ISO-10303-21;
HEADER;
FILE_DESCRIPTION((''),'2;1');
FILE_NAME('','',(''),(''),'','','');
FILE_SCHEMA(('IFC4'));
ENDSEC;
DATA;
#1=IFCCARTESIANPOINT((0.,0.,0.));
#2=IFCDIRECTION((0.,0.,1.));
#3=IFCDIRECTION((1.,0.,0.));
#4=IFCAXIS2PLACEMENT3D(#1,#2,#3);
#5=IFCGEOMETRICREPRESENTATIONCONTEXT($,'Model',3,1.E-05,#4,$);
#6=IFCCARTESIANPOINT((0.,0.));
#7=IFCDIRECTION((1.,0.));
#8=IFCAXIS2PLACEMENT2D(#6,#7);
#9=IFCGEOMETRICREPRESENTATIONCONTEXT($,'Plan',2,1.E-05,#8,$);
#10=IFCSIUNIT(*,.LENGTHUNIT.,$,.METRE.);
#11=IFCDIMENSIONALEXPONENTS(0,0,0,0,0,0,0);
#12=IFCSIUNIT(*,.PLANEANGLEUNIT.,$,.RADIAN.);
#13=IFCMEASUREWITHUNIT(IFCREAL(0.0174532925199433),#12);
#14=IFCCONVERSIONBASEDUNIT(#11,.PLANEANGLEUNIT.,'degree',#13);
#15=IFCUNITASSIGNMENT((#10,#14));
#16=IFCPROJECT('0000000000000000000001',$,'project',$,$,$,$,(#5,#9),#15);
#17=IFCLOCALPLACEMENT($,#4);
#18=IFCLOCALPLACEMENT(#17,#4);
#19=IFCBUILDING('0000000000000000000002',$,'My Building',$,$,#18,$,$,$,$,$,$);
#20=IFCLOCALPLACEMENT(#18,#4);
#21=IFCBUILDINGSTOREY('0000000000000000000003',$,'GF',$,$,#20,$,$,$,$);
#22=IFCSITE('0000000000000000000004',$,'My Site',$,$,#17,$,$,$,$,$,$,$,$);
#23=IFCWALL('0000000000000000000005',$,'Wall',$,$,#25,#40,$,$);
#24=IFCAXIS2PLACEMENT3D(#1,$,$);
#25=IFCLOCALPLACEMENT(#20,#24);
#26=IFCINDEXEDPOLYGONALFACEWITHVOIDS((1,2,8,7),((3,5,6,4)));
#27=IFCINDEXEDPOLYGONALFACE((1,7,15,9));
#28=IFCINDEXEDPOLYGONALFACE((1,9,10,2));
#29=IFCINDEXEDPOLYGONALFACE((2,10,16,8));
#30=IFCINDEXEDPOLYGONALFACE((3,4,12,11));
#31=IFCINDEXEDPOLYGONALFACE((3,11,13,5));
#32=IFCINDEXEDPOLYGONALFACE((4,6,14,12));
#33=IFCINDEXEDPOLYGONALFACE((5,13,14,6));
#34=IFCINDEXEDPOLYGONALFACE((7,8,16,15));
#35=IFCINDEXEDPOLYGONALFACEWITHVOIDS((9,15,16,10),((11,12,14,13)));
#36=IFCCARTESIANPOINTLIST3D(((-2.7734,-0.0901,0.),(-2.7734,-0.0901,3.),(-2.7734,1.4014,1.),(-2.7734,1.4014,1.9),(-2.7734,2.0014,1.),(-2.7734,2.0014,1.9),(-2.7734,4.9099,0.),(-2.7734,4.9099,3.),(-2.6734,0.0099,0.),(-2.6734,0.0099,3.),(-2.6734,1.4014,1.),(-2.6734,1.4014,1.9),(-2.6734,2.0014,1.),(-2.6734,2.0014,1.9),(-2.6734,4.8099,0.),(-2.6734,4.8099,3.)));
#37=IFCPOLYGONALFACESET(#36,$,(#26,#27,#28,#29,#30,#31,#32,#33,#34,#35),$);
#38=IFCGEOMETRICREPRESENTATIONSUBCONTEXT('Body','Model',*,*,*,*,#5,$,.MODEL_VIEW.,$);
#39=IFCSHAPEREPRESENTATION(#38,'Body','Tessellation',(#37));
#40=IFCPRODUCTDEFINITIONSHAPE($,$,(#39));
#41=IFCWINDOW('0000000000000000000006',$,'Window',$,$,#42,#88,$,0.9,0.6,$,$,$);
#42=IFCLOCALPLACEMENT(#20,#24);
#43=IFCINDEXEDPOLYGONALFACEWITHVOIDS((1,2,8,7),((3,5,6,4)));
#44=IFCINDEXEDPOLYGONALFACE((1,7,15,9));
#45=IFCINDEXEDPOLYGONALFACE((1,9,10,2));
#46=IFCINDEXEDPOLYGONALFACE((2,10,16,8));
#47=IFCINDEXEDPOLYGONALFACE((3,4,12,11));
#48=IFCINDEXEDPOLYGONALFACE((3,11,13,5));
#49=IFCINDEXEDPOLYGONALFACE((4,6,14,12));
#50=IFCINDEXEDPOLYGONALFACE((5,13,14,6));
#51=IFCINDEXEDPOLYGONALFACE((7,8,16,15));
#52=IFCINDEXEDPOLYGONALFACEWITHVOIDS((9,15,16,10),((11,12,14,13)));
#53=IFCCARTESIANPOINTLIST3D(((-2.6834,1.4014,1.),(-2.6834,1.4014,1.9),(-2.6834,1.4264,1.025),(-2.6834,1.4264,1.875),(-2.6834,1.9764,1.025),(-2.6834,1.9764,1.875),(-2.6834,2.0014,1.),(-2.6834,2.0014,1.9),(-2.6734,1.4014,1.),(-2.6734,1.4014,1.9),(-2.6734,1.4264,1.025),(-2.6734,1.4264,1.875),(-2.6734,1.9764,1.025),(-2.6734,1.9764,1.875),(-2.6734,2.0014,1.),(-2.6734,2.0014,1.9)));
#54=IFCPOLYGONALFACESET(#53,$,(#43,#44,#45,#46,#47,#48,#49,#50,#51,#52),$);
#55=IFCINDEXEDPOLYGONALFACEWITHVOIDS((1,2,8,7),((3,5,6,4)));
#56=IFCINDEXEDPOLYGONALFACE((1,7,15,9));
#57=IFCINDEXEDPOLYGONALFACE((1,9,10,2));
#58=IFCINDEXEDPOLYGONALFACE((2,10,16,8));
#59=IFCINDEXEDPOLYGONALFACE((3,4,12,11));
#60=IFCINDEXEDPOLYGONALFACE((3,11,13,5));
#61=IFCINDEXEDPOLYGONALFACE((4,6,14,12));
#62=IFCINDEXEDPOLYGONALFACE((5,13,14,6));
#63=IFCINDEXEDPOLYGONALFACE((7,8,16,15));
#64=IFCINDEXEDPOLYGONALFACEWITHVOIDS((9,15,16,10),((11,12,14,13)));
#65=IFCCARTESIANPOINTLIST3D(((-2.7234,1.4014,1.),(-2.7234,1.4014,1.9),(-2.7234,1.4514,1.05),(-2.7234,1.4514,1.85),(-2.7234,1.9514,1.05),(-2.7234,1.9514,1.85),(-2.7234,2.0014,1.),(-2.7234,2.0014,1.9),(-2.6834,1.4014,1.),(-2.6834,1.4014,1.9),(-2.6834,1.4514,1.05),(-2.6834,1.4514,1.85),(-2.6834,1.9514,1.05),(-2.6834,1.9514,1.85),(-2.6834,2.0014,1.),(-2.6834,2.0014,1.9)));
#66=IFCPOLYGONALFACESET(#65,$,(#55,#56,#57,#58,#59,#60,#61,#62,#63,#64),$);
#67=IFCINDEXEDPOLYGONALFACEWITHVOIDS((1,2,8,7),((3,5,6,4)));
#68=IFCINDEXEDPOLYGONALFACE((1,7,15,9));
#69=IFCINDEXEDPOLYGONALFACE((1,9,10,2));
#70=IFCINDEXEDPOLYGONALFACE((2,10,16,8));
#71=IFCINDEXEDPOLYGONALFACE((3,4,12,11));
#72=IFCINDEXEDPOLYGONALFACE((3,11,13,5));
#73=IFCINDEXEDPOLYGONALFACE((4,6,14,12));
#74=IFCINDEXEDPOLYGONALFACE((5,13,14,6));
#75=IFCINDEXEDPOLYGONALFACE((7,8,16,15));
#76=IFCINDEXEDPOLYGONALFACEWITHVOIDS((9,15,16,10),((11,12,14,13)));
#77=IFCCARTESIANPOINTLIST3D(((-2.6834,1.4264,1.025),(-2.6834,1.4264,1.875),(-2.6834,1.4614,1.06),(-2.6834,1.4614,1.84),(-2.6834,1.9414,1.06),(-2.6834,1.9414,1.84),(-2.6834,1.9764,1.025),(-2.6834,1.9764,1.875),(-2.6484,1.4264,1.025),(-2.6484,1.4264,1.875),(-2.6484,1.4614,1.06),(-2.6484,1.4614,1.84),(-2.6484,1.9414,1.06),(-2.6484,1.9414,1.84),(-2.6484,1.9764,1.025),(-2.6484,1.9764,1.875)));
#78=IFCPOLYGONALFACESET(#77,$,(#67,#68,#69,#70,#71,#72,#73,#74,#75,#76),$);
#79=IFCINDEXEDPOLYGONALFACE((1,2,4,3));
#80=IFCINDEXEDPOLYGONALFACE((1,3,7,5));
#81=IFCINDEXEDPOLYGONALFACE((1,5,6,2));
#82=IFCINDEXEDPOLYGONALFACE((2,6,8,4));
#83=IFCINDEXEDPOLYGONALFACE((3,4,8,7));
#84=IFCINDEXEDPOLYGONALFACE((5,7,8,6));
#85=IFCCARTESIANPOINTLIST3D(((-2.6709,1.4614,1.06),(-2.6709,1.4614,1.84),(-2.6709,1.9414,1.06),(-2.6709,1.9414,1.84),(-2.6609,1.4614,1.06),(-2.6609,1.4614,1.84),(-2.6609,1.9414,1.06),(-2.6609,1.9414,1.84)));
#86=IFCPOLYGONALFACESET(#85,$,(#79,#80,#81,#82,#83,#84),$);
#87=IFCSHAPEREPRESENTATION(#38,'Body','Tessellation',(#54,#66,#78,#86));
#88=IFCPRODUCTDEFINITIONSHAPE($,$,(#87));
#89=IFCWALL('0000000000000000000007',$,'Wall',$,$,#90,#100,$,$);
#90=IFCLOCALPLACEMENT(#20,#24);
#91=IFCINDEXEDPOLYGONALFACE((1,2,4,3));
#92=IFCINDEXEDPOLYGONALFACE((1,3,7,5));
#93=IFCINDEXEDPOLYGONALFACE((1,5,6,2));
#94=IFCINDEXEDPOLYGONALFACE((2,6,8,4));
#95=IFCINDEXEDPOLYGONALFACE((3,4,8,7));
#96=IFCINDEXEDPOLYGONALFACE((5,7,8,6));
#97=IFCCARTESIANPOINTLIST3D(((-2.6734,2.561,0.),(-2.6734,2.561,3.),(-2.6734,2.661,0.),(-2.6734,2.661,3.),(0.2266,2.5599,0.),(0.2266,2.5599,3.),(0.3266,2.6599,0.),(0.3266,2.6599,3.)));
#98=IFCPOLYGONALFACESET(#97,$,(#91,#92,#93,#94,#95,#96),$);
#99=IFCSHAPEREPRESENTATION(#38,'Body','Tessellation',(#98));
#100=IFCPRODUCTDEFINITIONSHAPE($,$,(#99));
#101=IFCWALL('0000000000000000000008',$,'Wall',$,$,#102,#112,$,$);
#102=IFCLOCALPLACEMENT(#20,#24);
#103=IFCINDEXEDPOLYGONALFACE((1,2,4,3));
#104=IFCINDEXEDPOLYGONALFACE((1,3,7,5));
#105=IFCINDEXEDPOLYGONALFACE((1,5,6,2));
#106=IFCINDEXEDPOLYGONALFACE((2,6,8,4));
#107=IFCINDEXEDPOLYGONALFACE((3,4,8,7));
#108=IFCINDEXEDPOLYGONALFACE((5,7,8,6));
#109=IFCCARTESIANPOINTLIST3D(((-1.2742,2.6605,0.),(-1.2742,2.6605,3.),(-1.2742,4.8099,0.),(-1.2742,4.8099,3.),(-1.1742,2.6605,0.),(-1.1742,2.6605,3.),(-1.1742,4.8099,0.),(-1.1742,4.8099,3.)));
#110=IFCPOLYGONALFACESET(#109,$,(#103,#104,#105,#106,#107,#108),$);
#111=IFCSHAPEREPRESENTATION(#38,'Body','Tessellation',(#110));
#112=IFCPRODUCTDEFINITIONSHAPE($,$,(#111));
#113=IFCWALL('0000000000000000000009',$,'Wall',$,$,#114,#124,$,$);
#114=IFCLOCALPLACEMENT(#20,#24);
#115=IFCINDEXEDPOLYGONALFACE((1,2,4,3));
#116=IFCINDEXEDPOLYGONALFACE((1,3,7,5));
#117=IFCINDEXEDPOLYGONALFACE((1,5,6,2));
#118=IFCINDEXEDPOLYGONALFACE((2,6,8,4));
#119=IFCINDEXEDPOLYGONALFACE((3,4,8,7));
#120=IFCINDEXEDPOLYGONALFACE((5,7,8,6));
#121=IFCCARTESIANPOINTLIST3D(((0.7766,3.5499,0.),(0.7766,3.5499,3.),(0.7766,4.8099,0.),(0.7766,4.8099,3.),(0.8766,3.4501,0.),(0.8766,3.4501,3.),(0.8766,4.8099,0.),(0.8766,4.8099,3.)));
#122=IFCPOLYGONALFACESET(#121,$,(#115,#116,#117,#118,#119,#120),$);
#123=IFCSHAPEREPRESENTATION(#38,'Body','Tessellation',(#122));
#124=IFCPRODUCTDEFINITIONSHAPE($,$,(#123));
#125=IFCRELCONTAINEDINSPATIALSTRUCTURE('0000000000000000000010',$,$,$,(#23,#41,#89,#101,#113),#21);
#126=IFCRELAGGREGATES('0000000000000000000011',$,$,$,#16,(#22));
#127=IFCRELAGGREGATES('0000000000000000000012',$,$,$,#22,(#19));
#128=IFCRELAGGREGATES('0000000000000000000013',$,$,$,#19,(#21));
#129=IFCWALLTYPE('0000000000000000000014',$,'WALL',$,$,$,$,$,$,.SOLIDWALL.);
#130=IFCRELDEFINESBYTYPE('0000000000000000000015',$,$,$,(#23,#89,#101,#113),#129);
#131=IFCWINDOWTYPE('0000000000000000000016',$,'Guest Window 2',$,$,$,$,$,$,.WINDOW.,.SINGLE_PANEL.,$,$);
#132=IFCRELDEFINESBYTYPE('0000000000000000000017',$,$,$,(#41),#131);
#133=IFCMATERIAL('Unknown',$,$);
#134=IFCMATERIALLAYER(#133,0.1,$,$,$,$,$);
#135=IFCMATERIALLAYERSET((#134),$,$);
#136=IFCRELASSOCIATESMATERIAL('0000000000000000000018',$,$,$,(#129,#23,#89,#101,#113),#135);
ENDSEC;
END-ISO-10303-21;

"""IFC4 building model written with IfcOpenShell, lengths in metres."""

from ifc_helpers import new_model, entity, si_unit, converted_unit, frame, origin_with_axes, origin_2d_with_axis, place, context, subcontext, project, spatial, line, indexed_curve, outline, extrude, shape, source, transform, mapped, material, layer, layer_set, layer_usage, type_object, type_shapes, element, fill, save


model = new_model("IFC4")

# Units and contexts
model_context = context("Model", 3, precision=1e-05, world=origin_with_axes())
plan_context = context("Plan", 2, precision=1e-05, world=origin_2d_with_axis())
body_context_1 = subcontext(model_context, "Body", "Model", "MODEL_VIEW")
body_context_2 = subcontext(plan_context, "Body", "Plan", "PLAN_VIEW")
ifc_project = project(units=[si_unit("LENGTHUNIT", "METRE"), converted_unit("PLANEANGLEUNIT", "degree", entity("IfcReal", 0.0174532925199433), si_unit("PLANEANGLEUNIT", "RADIAN"), dimensions=[0, 0, 0, 0, 0, 0, 0])], contexts=[model_context, plan_context])

# Site, building, storey
site_placement = place(None, origin_with_axes())
site = spatial("IfcSite", under=ifc_project, at=site_placement, Name="My Site")
building_placement = place(site_placement, origin_with_axes())
building = spatial("IfcBuilding", under=site, at=building_placement, Name="My Building")
storey_placement = place(building_placement, origin_with_axes())
storey = spatial("IfcBuildingStorey", under=building, at=storey_placement, Name="GF")

# Shared definitions
ifc_material = material(Name="Unknown")

# Shared definitions
ifc_layer = layer(ifc_material, 0.1)
ifc_layer_set = layer_set([ifc_layer])
wall_type = type_object("IfcWallType", Name="WALL", PredefinedType="SOLIDWALL", material=ifc_layer_set)

# Wall, opening, window
ifc_layer_usage_1 = layer_usage(ifc_layer_set, "AXIS2", "POSITIVE", 0.0)
wall_1_placement = place(storey_placement, frame((-2.7734, 4.9099, 0.0), z_axis=(0.0, 0.0, 1.0), x_axis=(0.0, -1.0, 0.0)))
wall_1 = element("IfcWall", 1, at=wall_1_placement, inside=storey, type_object=wall_type, material=ifc_layer_usage_1, Name="Wall", context=body_context_1, shape_type="SweptSolid", body=[
    extrude(outline(indexed_curve([(0.0, 0.0), (0.1, 0.1), (4.9, 0.1), (5.0, 0.0)], segments=[line(1, 2, 3, 4, 1)])), origin_with_axes(), (0.0, 0.0, 1.0), 3.0),
])
shared_shape_1 = source(origin_with_axes(), body_context_1, "Body", "SweptSolid", [
    extrude(outline(indexed_curve([(0.0, 0.0), (0.6, 0.0), (0.6, 0.9), (0.0, 0.9)], segments=[line(1, 2, 3, 4, 1)])), frame((0.0, -0.6, 0.0), z_axis=(0.0, -1.0, 0.0), x_axis=(1.0, 0.0, 0.0)), (0.0, 0.0, -1.0), 1.2),
])
opening_1_placement = place(wall_1_placement, frame((2.9085, 0.0, 1.0), z_axis=(0.0, 0.0, 1.0), x_axis=(1.0, 0.0, 0.0)))
opening_1 = element("IfcOpeningElement", 2, at=opening_1_placement, cuts=wall_1, PredefinedType="OPENING", context=body_context_1, shape_type="MappedRepresentation", body=[
    mapped(shared_shape_1, transform((0.0, 0.0, 0.0), x_axis=(1.0, 0.0, 0.0), y_axis=(0.0, 1.0, 0.0), z_axis=(0.0, 0.0, 1.0), scale=1.0)),
])
window_type_1 = type_object("IfcWindowType", Name="Guest Window 2", PartitioningType="SINGLE_PANEL", PredefinedType="WINDOW")
shared_shape_2 = source(origin_with_axes(), body_context_1, "Body", "SweptSolid", [
    extrude(outline(indexed_curve([(0.0, 0.0), (0.6, 0.0), (0.6, 0.9), (0.0, 0.9)], segments=[line(1, 2, 3, 4, 1)]), holes=[indexed_curve([(0.025, 0.025), (0.575, 0.025), (0.575, 0.875), (0.025, 0.875)], segments=[line(1, 2, 3, 4, 1)])]), frame((0.0, 0.09, 0.0), z_axis=(0.0, -1.0, 0.0), x_axis=(1.0, 0.0, 0.0)), (0.0, 0.0, -1.0), 0.01),
    extrude(outline(indexed_curve([(0.0, 0.0), (0.6, 0.0), (0.6, 0.9), (0.0, 0.9)], segments=[line(1, 2, 3, 4, 1)]), holes=[indexed_curve([(0.05, 0.05), (0.55, 0.05), (0.55, 0.85), (0.05, 0.85)], segments=[line(1, 2, 3, 4, 1)])]), frame((0.0, 0.05, 0.0), z_axis=(0.0, -1.0, 0.0), x_axis=(1.0, 0.0, 0.0)), (0.0, 0.0, -1.0), 0.04),
    extrude(outline(indexed_curve([(0.0, 0.0), (0.55, 0.0), (0.55, 0.85), (0.0, 0.85)], segments=[line(1, 2, 3, 4, 1)]), holes=[indexed_curve([(0.035, 0.035), (0.515, 0.035), (0.515, 0.815), (0.035, 0.815)], segments=[line(1, 2, 3, 4, 1)])]), frame((0.025, 0.09, 0.025), z_axis=(0.0, -1.0, 0.0), x_axis=(1.0, 0.0, 0.0)), (0.0, 0.0, -1.0), 0.035),
    extrude(outline(indexed_curve([(0.035, 0.035), (0.515, 0.035), (0.515, 0.815), (0.035, 0.815)], segments=[line(1, 2, 3, 4, 1)])), frame((0.025, 0.1025, 0.025), z_axis=(0.0, -1.0, 0.0), x_axis=(1.0, 0.0, 0.0)), (0.0, 0.0, -1.0), 0.01),
])
shared_shape_3 = source(origin_with_axes(), body_context_2, "Body", "Curve2D", [
    entity("IfcIndexedPolyCurve", entity("IfcCartesianPointList2D", [[0.05, 0.05], [0.55, 0.05]])),
    entity("IfcIndexedPolyCurve", entity("IfcCartesianPointList2D", [[0.0, 0.1], [0.025, 0.1], [0.025, 0.09], [0.05, 0.09], [0.05, 0.05], [0.0, 0.05]]), [entity("IfcLineIndex", [1, 2, 3, 4, 5, 6, 1])]),
    entity("IfcIndexedPolyCurve", entity("IfcCartesianPointList2D", [[0.6, 0.1], [0.575, 0.1], [0.575, 0.09], [0.55, 0.09], [0.55, 0.05], [0.6, 0.05]]), [entity("IfcLineIndex", [1, 2, 3, 4, 5, 6, 1])]),
    entity("IfcIndexedPolyCurve", entity("IfcCartesianPointList2D", [[0.025, 0.09], [0.06, 0.09], [0.06, 0.125], [0.025, 0.125]]), [entity("IfcLineIndex", [1, 2, 3, 4, 1])]),
    entity("IfcIndexedPolyCurve", entity("IfcCartesianPointList2D", [[0.575, 0.09], [0.54, 0.09], [0.54, 0.125], [0.575, 0.125]]), [entity("IfcLineIndex", [1, 2, 3, 4, 1])]),
    entity("IfcIndexedPolyCurve", entity("IfcCartesianPointList2D", [[0.06, 0.09], [0.54, 0.09]])),
    entity("IfcIndexedPolyCurve", entity("IfcCartesianPointList2D", [[0.06, 0.125], [0.54, 0.125]])),
    entity("IfcIndexedPolyCurve", entity("IfcCartesianPointList2D", [[0.06, 0.1075], [0.54, 0.1075]])),
])
type_shapes(window_type_1, [shared_shape_2, shared_shape_3])
window_1_placement = place(opening_1_placement, origin_with_axes())
window_1 = element("IfcWindow", 3, at=window_1_placement, inside=storey, type_object=window_type_1, Name="Window", OverallHeight=0.9, OverallWidth=0.6, shapes=[
    shape(body_context_1, "Body", "MappedRepresentation", [mapped(shared_shape_2, transform((0.0, 0.0, 0.0), x_axis=(1.0, 0.0, 0.0), y_axis=(0.0, 1.0, 0.0), z_axis=(0.0, 0.0, 1.0), scale=1.0))]),
    shape(body_context_2, "Body", "MappedRepresentation", [mapped(shared_shape_3, transform((0.0, 0.0, 0.0), x_axis=(1.0, 0.0, 0.0), y_axis=(0.0, 1.0, 0.0), z_axis=(0.0, 0.0, 1.0), scale=1.0))]),
])
fill(opening_1, window_1)

# Walls
ifc_layer_usage_2 = layer_usage(ifc_layer_set, "AXIS2", "POSITIVE", 0.0)
wall_2_placement = place(storey_placement, frame((0.3266, 2.6599, 0.0), z_axis=(0.0, 0.0, 1.0), x_axis=(-1.0, 0.000374, 0.0)))
element("IfcWall", 4, at=wall_2_placement, inside=storey, type_object=wall_type, material=ifc_layer_usage_2, Name="Wall", context=body_context_1, shape_type="SweptSolid", body=[
    extrude(outline(indexed_curve([(0.0, 0.0), (0.1, 0.1), (3.0, 0.1), (3.0, 0.0)], segments=[line(1, 2, 3, 4, 1)])), origin_with_axes(), (0.0, 0.0, 1.0), 3.0),
])
ifc_layer_usage_3 = layer_usage(ifc_layer_set, "AXIS2", "POSITIVE", 0.0)
wall_3_placement = place(storey_placement, frame((-1.2742, 4.8099, 0.0), z_axis=(0.0, 0.0, 1.0), x_axis=(-0.000003, -1.0, 0.0)))
element("IfcWall", 5, at=wall_3_placement, inside=storey, type_object=wall_type, material=ifc_layer_usage_3, Name="Wall", context=body_context_1, shape_type="SweptSolid", body=[
    extrude(outline(indexed_curve([(0.0, 0.0), (0.0, 0.1), (2.1494, 0.1), (2.1494, 0.0)], segments=[line(1, 2, 3, 4, 1)])), origin_with_axes(), (0.0, 0.0, 1.0), 3.0),
])
ifc_layer_usage_4 = layer_usage(ifc_layer_set, "AXIS2", "POSITIVE", 0.0)
wall_4_placement = place(storey_placement, frame((0.7766, 4.8099, 0.0), z_axis=(0.0, 0.0, 1.0), x_axis=(0.0, -1.0, 0.0)))
element("IfcWall", 6, at=wall_4_placement, inside=storey, type_object=wall_type, material=ifc_layer_usage_4, Name="Wall", context=body_context_1, shape_type="SweptSolid", body=[
    extrude(outline(indexed_curve([(0.0, 0.0), (0.0, 0.1), (1.3598, 0.1), (1.26, 0.0)], segments=[line(1, 2, 3, 4, 1)])), origin_with_axes(), (0.0, 0.0, 1.0), 3.0),
])

save(model, "model.ifc")
